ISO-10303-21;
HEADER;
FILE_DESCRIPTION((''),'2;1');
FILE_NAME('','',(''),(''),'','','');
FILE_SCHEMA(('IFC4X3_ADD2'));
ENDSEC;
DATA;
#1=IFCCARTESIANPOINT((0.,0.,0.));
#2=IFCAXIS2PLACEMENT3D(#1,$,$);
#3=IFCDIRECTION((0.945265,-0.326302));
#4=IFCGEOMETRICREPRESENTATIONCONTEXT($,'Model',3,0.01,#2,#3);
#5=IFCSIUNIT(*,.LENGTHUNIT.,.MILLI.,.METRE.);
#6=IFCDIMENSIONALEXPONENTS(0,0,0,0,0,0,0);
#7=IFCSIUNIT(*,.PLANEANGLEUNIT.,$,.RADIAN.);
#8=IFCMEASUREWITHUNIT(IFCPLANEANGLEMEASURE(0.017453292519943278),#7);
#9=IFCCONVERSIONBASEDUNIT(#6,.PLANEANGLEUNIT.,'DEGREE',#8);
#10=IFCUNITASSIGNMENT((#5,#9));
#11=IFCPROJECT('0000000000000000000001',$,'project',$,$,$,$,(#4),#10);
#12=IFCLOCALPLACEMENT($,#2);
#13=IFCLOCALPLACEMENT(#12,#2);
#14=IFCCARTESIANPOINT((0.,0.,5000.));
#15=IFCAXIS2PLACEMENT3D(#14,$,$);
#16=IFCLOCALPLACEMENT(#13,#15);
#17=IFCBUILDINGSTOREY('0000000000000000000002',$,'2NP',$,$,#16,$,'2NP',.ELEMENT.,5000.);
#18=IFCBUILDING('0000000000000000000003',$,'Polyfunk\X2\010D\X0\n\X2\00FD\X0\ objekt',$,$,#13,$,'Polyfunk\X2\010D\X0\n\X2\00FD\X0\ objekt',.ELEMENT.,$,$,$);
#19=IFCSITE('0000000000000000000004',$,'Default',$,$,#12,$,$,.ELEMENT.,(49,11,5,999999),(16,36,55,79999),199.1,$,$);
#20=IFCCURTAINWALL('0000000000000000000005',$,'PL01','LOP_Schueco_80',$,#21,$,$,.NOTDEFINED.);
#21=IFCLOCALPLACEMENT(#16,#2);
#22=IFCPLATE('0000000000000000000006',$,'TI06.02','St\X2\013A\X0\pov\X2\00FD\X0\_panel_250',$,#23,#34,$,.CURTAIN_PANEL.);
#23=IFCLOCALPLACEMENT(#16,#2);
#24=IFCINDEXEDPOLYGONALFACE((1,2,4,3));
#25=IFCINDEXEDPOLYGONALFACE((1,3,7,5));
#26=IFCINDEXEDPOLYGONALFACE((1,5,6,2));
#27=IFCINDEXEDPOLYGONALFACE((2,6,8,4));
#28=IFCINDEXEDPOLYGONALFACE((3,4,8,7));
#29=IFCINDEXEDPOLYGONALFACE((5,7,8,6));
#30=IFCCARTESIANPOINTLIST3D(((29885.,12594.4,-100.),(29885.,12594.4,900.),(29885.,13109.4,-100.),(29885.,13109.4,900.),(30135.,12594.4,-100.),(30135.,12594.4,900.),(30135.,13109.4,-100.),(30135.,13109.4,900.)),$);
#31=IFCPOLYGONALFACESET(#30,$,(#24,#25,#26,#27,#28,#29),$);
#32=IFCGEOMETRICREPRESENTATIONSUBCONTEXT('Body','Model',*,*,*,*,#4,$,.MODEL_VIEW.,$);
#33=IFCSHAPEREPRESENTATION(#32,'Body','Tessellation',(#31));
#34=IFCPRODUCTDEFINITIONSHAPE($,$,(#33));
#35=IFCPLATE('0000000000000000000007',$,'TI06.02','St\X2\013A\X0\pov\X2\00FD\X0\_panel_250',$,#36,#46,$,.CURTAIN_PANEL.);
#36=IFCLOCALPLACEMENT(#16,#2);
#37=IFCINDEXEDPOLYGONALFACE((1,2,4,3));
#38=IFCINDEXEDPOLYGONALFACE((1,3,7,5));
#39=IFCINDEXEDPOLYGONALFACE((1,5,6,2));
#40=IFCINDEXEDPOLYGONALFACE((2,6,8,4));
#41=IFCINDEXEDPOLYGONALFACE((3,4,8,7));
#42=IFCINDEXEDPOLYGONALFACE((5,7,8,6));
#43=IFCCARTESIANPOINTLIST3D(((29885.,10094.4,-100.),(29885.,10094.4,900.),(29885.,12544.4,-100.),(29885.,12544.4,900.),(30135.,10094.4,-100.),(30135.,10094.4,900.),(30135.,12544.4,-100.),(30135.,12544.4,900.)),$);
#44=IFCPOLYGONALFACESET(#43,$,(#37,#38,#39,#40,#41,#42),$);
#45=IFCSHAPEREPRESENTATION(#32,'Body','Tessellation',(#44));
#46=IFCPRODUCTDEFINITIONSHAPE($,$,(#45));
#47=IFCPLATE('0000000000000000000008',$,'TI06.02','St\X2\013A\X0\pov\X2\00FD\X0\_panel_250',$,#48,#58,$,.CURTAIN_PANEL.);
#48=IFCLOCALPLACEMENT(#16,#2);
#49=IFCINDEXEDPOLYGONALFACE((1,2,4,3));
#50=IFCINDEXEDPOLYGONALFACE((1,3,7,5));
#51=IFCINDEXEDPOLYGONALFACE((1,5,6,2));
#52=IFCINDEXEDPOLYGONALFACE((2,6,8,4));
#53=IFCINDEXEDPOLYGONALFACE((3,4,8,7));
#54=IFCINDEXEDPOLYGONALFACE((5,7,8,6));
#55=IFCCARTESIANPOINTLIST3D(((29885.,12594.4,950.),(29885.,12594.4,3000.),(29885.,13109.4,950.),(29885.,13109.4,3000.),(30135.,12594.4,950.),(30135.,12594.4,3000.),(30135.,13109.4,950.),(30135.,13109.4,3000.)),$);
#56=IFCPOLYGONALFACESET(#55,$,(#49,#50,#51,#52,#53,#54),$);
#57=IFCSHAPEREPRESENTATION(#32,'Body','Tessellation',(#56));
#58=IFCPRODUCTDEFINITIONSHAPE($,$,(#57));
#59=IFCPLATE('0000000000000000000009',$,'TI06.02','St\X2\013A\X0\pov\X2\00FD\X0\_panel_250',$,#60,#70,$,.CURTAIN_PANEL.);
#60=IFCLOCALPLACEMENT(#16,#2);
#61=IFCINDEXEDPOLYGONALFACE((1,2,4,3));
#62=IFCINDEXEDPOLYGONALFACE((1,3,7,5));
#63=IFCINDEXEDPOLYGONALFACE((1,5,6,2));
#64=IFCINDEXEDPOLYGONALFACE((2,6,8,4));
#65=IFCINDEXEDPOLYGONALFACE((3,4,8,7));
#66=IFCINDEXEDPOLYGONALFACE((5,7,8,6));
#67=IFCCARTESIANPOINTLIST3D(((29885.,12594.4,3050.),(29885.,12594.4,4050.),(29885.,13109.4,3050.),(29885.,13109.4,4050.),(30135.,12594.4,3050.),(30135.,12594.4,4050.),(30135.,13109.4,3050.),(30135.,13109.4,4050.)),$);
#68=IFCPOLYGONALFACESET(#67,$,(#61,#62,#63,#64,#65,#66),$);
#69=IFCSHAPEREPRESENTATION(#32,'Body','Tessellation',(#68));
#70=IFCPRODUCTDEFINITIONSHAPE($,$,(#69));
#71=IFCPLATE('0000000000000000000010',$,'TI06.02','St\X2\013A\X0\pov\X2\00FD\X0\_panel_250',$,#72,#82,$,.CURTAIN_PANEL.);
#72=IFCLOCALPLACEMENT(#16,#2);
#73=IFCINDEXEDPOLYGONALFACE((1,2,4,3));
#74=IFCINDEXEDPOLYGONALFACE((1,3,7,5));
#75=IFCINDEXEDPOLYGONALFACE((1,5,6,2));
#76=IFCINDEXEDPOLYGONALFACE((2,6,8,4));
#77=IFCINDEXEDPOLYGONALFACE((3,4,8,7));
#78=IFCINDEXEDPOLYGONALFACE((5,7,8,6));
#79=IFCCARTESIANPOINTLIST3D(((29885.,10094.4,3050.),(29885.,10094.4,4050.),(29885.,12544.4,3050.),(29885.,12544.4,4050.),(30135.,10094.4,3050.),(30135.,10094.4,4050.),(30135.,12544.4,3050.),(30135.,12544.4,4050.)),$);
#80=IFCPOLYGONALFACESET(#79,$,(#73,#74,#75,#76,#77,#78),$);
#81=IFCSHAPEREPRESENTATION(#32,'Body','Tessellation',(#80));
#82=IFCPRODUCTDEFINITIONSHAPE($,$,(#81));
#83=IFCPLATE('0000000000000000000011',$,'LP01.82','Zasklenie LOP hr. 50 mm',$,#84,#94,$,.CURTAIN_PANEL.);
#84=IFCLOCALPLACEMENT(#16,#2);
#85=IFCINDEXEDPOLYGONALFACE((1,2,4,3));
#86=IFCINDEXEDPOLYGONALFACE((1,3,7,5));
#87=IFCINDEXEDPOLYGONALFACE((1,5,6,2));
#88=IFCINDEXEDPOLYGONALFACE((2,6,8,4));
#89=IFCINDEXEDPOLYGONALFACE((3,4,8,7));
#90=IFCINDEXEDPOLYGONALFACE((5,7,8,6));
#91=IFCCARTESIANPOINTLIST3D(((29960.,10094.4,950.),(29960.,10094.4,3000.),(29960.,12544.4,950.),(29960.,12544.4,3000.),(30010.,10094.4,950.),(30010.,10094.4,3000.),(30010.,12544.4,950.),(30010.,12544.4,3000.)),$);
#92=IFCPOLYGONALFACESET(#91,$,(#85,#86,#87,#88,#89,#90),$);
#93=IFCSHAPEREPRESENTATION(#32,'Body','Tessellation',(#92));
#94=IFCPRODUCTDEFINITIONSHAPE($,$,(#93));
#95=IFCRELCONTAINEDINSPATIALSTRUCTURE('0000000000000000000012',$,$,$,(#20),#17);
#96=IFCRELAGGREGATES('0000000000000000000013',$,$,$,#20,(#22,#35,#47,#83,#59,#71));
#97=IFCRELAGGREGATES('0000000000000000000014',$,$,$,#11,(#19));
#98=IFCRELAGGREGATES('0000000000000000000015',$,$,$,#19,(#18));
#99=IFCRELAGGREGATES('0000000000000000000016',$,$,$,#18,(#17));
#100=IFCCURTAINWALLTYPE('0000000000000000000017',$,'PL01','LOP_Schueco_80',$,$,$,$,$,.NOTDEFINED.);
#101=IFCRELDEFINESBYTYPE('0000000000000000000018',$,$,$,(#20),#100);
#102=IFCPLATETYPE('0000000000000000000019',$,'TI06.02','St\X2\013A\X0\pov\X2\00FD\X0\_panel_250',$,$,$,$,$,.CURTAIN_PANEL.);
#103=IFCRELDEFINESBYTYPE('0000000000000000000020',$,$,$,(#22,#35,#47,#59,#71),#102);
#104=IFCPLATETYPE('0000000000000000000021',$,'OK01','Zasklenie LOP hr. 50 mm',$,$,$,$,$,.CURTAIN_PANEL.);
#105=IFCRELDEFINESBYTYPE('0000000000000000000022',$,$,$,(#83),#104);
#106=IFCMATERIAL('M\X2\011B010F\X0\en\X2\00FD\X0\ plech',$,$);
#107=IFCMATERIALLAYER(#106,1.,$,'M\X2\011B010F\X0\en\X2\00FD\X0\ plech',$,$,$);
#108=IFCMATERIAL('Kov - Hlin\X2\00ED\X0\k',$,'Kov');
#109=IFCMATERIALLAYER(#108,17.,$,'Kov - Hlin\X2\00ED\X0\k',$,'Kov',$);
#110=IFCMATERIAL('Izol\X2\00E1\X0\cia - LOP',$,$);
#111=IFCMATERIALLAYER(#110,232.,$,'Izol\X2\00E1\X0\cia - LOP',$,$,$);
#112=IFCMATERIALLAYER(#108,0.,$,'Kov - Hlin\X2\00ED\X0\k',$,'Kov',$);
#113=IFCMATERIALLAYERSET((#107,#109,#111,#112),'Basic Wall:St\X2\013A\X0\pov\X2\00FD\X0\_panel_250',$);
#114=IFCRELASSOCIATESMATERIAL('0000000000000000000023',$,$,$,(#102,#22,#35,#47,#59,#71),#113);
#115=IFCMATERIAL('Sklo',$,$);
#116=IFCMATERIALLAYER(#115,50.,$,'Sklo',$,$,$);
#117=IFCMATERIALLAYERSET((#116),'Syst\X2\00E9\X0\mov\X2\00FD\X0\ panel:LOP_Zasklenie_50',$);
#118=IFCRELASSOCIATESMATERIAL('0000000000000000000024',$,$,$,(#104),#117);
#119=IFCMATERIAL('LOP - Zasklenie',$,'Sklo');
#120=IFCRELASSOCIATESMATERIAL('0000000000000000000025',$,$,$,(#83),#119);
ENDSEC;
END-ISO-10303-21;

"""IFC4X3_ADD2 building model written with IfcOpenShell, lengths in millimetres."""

from ifc_helpers import new_model, entity, si_unit, converted_unit, direction, frame, frame_2d, origin, origin_2d_with_axis, place, context, subcontext, project, spatial, rectangle, extrude, source, transform, mapped, material, layer, layer_set, layer_usage, type_object, type_shapes, element, aggregate, save


model = new_model("IFC4X3_ADD2")

# Units and contexts
model_context = context("Model", 3, precision=0.01, world=origin(), true_north=direction((0.945265, -0.326302)))
body_context = subcontext(model_context, "Body", "Model", "MODEL_VIEW")
ifc_project = project(units=[si_unit("LENGTHUNIT", "METRE", prefix="MILLI"), converted_unit("PLANEANGLEUNIT", "DEGREE", entity("IfcPlaneAngleMeasure", 0.017453292519943278), si_unit("PLANEANGLEUNIT", "RADIAN"), dimensions=[0, 0, 0, 0, 0, 0, 0])], contexts=[model_context])

# Site, building, storey
site_placement = place(None, origin())
site = spatial("IfcSite", under=ifc_project, at=site_placement, Name="Default", CompositionType="ELEMENT", RefLatitude=(49, 11, 5, 999999), RefLongitude=(16, 36, 55, 79999), RefElevation=199.1)
building_placement = place(site_placement, origin())
building = spatial("IfcBuilding", under=site, at=building_placement, Name="Polyfunkčný objekt", LongName="Polyfunkčný objekt", CompositionType="ELEMENT")
storey_placement = place(building_placement, frame((0.0, 0.0, 5000.0)))
storey = spatial("IfcBuildingStorey", under=building, at=storey_placement, Name="2NP", LongName="2NP", CompositionType="ELEMENT", Elevation=5000.0)

# Curtain wall
curtain_wall_type = type_object("IfcCurtainWallType", Name="PL01", Description="LOP_Schueco_80", PredefinedType="NOTDEFINED")
curtain_wall_1_placement = place(storey_placement, frame((0.0, 0.0, -5000.0)))
curtain_wall_1 = element("IfcCurtainWall", 1, at=curtain_wall_1_placement, inside=storey, type_object=curtain_wall_type, Name="PL01", Description="LOP_Schueco_80", PredefinedType="NOTDEFINED")

# Plates
ifc_material_1 = material(Name="Měďený plech")
ifc_layer_1 = layer(ifc_material_1, 1.0, Name="Měďený plech")
ifc_material_2 = material(Name="Kov - Hliník", Category="Kov")
ifc_layer_2 = layer(ifc_material_2, 17.0, Name="Kov - Hliník", Category="Kov")
ifc_material_3 = material(Name="Izolácia - LOP")
ifc_layer_3 = layer(ifc_material_3, 232.0, Name="Izolácia - LOP")
ifc_layer_4 = layer(ifc_material_2, 0.0, Name="Kov - Hliník", Category="Kov")
ifc_layer_set_1 = layer_set([ifc_layer_1, ifc_layer_2, ifc_layer_3, ifc_layer_4], Name="Basic Wall:Stĺpový_panel_250")
ifc_layer_usage_1 = layer_usage(ifc_layer_set_1, "AXIS2", "POSITIVE", -125.0)
plate_type_1 = type_object("IfcPlateType", Name="TI06.02", Description="Stĺpový_panel_250", PredefinedType="CURTAIN_PANEL", material=ifc_layer_set_1)
plate_1_placement = place(storey_placement, frame((30010.0, 13109.4, -100.0), z_axis=(0.0, 0.0, 1.0), x_axis=(0.0, -1.0, 0.0)))
plate_1 = element("IfcPlate", 2, at=plate_1_placement, type_object=plate_type_1, material=ifc_layer_usage_1, Name="TI06.02", Description="Stĺpový_panel_250", PredefinedType="CURTAIN_PANEL", context=body_context, shape_type="SweptSolid", body=[
    extrude(rectangle(XDim=250.0, YDim=515.0, at=frame_2d((0.0, 0.0), x_axis=(1.0, 0.0))), frame((257.5, 0.0, 0.0), z_axis=(0.0, 0.0, 1.0), x_axis=(0.0, 1.0, 0.0)), (0.0, 0.0, 1.0), 1000.0),
])
ifc_layer_usage_2 = layer_usage(ifc_layer_set_1, "AXIS2", "POSITIVE", -125.0)
plate_2_placement = place(storey_placement, frame((30010.0, 12544.4, -100.0), z_axis=(0.0, 0.0, 1.0), x_axis=(0.0, -1.0, 0.0)))
plate_2 = element("IfcPlate", 3, at=plate_2_placement, type_object=plate_type_1, material=ifc_layer_usage_2, Name="TI06.02", Description="Stĺpový_panel_250", PredefinedType="CURTAIN_PANEL", context=body_context, shape_type="SweptSolid", body=[
    extrude(rectangle(XDim=250.0, YDim=2450.0, at=frame_2d((0.0, 0.0), x_axis=(1.0, 0.0))), frame((1225.0, 0.0, 0.0), z_axis=(0.0, 0.0, 1.0), x_axis=(0.0, 1.0, 0.0)), (0.0, 0.0, 1.0), 1000.0),
])
ifc_layer_usage_3 = layer_usage(ifc_layer_set_1, "AXIS2", "POSITIVE", -125.0)
plate_3_placement = place(storey_placement, frame((30010.0, 13109.4, 950.0), z_axis=(0.0, 0.0, 1.0), x_axis=(0.0, -1.0, 0.0)))
plate_3 = element("IfcPlate", 4, at=plate_3_placement, type_object=plate_type_1, material=ifc_layer_usage_3, Name="TI06.02", Description="Stĺpový_panel_250", PredefinedType="CURTAIN_PANEL", context=body_context, shape_type="SweptSolid", body=[
    extrude(rectangle(XDim=250.0, YDim=515.0, at=frame_2d((0.0, 0.0), x_axis=(1.0, 0.0))), frame((257.5, 0.0, 0.0), z_axis=(0.0, 0.0, 1.0), x_axis=(0.0, 1.0, 0.0)), (0.0, 0.0, 1.0), 2050.0),
])
ifc_layer_usage_4 = layer_usage(ifc_layer_set_1, "AXIS2", "POSITIVE", -125.0)
plate_4_placement = place(storey_placement, frame((30010.0, 13109.4, 3050.0), z_axis=(0.0, 0.0, 1.0), x_axis=(0.0, -1.0, 0.0)))
plate_4 = element("IfcPlate", 5, at=plate_4_placement, type_object=plate_type_1, material=ifc_layer_usage_4, Name="TI06.02", Description="Stĺpový_panel_250", PredefinedType="CURTAIN_PANEL", context=body_context, shape_type="SweptSolid", body=[
    extrude(rectangle(XDim=250.0, YDim=515.0, at=frame_2d((0.0, 0.0), x_axis=(1.0, 0.0))), frame((257.5, 0.0, 0.0), z_axis=(0.0, 0.0, 1.0), x_axis=(0.0, 1.0, 0.0)), (0.0, 0.0, 1.0), 1000.0),
])
ifc_layer_usage_5 = layer_usage(ifc_layer_set_1, "AXIS2", "POSITIVE", -125.0)
plate_5_placement = place(storey_placement, frame((30010.0, 12544.4, 3050.0), z_axis=(0.0, 0.0, 1.0), x_axis=(0.0, -1.0, 0.0)))
plate_5 = element("IfcPlate", 6, at=plate_5_placement, type_object=plate_type_1, material=ifc_layer_usage_5, Name="TI06.02", Description="Stĺpový_panel_250", PredefinedType="CURTAIN_PANEL", context=body_context, shape_type="SweptSolid", body=[
    extrude(rectangle(XDim=250.0, YDim=2450.0, at=frame_2d((0.0, 0.0), x_axis=(1.0, 0.0))), frame((1225.0, 0.0, 0.0), z_axis=(0.0, 0.0, 1.0), x_axis=(0.0, 1.0, 0.0)), (0.0, 0.0, 1.0), 1000.0),
])
ifc_material_4 = material(Name="LOP - Zasklenie", Category="Sklo")
ifc_material_5 = material(Name="Sklo")
ifc_layer_5 = layer(ifc_material_5, 50.0, Name="Sklo")
ifc_layer_set_2 = layer_set([ifc_layer_5], Name="Systémový panel:LOP_Zasklenie_50")
plate_type_2 = type_object("IfcPlateType", Name="OK01", Description="Zasklenie LOP hr. 50 mm", PredefinedType="CURTAIN_PANEL", material=ifc_layer_set_2)
shared_shape_1 = source(origin(), body_context, "Body", "SweptSolid", [
    extrude(rectangle(XDim=50.0, YDim=2450.0, at=origin_2d_with_axis()), frame((0.0, -25.0, 0.0), z_axis=(0.0, 0.0, 1.0), x_axis=(0.0, 1.0, 0.0)), (0.0, 0.0, 1.0), 2050.0),
])
type_shapes(plate_type_2, [shared_shape_1])
plate_6_placement = place(curtain_wall_1_placement, frame((30010.0, 11319.4, 5950.0), z_axis=(0.0, 0.0, 1.0), x_axis=(0.0, -1.0, 0.0)))
plate_6 = element("IfcPlate", 7, at=plate_6_placement, type_object=plate_type_2, material=ifc_material_4, Name="LP01.82", Description="Zasklenie LOP hr. 50 mm", PredefinedType="CURTAIN_PANEL", context=body_context, shape_type="MappedRepresentation", body=[
    mapped(shared_shape_1, transform((0.0, 0.0, 0.0), scale=1.0)),
])
aggregate(curtain_wall_1, [plate_1, plate_2, plate_3, plate_6, plate_4, plate_5])

save(model, "model.ifc")
